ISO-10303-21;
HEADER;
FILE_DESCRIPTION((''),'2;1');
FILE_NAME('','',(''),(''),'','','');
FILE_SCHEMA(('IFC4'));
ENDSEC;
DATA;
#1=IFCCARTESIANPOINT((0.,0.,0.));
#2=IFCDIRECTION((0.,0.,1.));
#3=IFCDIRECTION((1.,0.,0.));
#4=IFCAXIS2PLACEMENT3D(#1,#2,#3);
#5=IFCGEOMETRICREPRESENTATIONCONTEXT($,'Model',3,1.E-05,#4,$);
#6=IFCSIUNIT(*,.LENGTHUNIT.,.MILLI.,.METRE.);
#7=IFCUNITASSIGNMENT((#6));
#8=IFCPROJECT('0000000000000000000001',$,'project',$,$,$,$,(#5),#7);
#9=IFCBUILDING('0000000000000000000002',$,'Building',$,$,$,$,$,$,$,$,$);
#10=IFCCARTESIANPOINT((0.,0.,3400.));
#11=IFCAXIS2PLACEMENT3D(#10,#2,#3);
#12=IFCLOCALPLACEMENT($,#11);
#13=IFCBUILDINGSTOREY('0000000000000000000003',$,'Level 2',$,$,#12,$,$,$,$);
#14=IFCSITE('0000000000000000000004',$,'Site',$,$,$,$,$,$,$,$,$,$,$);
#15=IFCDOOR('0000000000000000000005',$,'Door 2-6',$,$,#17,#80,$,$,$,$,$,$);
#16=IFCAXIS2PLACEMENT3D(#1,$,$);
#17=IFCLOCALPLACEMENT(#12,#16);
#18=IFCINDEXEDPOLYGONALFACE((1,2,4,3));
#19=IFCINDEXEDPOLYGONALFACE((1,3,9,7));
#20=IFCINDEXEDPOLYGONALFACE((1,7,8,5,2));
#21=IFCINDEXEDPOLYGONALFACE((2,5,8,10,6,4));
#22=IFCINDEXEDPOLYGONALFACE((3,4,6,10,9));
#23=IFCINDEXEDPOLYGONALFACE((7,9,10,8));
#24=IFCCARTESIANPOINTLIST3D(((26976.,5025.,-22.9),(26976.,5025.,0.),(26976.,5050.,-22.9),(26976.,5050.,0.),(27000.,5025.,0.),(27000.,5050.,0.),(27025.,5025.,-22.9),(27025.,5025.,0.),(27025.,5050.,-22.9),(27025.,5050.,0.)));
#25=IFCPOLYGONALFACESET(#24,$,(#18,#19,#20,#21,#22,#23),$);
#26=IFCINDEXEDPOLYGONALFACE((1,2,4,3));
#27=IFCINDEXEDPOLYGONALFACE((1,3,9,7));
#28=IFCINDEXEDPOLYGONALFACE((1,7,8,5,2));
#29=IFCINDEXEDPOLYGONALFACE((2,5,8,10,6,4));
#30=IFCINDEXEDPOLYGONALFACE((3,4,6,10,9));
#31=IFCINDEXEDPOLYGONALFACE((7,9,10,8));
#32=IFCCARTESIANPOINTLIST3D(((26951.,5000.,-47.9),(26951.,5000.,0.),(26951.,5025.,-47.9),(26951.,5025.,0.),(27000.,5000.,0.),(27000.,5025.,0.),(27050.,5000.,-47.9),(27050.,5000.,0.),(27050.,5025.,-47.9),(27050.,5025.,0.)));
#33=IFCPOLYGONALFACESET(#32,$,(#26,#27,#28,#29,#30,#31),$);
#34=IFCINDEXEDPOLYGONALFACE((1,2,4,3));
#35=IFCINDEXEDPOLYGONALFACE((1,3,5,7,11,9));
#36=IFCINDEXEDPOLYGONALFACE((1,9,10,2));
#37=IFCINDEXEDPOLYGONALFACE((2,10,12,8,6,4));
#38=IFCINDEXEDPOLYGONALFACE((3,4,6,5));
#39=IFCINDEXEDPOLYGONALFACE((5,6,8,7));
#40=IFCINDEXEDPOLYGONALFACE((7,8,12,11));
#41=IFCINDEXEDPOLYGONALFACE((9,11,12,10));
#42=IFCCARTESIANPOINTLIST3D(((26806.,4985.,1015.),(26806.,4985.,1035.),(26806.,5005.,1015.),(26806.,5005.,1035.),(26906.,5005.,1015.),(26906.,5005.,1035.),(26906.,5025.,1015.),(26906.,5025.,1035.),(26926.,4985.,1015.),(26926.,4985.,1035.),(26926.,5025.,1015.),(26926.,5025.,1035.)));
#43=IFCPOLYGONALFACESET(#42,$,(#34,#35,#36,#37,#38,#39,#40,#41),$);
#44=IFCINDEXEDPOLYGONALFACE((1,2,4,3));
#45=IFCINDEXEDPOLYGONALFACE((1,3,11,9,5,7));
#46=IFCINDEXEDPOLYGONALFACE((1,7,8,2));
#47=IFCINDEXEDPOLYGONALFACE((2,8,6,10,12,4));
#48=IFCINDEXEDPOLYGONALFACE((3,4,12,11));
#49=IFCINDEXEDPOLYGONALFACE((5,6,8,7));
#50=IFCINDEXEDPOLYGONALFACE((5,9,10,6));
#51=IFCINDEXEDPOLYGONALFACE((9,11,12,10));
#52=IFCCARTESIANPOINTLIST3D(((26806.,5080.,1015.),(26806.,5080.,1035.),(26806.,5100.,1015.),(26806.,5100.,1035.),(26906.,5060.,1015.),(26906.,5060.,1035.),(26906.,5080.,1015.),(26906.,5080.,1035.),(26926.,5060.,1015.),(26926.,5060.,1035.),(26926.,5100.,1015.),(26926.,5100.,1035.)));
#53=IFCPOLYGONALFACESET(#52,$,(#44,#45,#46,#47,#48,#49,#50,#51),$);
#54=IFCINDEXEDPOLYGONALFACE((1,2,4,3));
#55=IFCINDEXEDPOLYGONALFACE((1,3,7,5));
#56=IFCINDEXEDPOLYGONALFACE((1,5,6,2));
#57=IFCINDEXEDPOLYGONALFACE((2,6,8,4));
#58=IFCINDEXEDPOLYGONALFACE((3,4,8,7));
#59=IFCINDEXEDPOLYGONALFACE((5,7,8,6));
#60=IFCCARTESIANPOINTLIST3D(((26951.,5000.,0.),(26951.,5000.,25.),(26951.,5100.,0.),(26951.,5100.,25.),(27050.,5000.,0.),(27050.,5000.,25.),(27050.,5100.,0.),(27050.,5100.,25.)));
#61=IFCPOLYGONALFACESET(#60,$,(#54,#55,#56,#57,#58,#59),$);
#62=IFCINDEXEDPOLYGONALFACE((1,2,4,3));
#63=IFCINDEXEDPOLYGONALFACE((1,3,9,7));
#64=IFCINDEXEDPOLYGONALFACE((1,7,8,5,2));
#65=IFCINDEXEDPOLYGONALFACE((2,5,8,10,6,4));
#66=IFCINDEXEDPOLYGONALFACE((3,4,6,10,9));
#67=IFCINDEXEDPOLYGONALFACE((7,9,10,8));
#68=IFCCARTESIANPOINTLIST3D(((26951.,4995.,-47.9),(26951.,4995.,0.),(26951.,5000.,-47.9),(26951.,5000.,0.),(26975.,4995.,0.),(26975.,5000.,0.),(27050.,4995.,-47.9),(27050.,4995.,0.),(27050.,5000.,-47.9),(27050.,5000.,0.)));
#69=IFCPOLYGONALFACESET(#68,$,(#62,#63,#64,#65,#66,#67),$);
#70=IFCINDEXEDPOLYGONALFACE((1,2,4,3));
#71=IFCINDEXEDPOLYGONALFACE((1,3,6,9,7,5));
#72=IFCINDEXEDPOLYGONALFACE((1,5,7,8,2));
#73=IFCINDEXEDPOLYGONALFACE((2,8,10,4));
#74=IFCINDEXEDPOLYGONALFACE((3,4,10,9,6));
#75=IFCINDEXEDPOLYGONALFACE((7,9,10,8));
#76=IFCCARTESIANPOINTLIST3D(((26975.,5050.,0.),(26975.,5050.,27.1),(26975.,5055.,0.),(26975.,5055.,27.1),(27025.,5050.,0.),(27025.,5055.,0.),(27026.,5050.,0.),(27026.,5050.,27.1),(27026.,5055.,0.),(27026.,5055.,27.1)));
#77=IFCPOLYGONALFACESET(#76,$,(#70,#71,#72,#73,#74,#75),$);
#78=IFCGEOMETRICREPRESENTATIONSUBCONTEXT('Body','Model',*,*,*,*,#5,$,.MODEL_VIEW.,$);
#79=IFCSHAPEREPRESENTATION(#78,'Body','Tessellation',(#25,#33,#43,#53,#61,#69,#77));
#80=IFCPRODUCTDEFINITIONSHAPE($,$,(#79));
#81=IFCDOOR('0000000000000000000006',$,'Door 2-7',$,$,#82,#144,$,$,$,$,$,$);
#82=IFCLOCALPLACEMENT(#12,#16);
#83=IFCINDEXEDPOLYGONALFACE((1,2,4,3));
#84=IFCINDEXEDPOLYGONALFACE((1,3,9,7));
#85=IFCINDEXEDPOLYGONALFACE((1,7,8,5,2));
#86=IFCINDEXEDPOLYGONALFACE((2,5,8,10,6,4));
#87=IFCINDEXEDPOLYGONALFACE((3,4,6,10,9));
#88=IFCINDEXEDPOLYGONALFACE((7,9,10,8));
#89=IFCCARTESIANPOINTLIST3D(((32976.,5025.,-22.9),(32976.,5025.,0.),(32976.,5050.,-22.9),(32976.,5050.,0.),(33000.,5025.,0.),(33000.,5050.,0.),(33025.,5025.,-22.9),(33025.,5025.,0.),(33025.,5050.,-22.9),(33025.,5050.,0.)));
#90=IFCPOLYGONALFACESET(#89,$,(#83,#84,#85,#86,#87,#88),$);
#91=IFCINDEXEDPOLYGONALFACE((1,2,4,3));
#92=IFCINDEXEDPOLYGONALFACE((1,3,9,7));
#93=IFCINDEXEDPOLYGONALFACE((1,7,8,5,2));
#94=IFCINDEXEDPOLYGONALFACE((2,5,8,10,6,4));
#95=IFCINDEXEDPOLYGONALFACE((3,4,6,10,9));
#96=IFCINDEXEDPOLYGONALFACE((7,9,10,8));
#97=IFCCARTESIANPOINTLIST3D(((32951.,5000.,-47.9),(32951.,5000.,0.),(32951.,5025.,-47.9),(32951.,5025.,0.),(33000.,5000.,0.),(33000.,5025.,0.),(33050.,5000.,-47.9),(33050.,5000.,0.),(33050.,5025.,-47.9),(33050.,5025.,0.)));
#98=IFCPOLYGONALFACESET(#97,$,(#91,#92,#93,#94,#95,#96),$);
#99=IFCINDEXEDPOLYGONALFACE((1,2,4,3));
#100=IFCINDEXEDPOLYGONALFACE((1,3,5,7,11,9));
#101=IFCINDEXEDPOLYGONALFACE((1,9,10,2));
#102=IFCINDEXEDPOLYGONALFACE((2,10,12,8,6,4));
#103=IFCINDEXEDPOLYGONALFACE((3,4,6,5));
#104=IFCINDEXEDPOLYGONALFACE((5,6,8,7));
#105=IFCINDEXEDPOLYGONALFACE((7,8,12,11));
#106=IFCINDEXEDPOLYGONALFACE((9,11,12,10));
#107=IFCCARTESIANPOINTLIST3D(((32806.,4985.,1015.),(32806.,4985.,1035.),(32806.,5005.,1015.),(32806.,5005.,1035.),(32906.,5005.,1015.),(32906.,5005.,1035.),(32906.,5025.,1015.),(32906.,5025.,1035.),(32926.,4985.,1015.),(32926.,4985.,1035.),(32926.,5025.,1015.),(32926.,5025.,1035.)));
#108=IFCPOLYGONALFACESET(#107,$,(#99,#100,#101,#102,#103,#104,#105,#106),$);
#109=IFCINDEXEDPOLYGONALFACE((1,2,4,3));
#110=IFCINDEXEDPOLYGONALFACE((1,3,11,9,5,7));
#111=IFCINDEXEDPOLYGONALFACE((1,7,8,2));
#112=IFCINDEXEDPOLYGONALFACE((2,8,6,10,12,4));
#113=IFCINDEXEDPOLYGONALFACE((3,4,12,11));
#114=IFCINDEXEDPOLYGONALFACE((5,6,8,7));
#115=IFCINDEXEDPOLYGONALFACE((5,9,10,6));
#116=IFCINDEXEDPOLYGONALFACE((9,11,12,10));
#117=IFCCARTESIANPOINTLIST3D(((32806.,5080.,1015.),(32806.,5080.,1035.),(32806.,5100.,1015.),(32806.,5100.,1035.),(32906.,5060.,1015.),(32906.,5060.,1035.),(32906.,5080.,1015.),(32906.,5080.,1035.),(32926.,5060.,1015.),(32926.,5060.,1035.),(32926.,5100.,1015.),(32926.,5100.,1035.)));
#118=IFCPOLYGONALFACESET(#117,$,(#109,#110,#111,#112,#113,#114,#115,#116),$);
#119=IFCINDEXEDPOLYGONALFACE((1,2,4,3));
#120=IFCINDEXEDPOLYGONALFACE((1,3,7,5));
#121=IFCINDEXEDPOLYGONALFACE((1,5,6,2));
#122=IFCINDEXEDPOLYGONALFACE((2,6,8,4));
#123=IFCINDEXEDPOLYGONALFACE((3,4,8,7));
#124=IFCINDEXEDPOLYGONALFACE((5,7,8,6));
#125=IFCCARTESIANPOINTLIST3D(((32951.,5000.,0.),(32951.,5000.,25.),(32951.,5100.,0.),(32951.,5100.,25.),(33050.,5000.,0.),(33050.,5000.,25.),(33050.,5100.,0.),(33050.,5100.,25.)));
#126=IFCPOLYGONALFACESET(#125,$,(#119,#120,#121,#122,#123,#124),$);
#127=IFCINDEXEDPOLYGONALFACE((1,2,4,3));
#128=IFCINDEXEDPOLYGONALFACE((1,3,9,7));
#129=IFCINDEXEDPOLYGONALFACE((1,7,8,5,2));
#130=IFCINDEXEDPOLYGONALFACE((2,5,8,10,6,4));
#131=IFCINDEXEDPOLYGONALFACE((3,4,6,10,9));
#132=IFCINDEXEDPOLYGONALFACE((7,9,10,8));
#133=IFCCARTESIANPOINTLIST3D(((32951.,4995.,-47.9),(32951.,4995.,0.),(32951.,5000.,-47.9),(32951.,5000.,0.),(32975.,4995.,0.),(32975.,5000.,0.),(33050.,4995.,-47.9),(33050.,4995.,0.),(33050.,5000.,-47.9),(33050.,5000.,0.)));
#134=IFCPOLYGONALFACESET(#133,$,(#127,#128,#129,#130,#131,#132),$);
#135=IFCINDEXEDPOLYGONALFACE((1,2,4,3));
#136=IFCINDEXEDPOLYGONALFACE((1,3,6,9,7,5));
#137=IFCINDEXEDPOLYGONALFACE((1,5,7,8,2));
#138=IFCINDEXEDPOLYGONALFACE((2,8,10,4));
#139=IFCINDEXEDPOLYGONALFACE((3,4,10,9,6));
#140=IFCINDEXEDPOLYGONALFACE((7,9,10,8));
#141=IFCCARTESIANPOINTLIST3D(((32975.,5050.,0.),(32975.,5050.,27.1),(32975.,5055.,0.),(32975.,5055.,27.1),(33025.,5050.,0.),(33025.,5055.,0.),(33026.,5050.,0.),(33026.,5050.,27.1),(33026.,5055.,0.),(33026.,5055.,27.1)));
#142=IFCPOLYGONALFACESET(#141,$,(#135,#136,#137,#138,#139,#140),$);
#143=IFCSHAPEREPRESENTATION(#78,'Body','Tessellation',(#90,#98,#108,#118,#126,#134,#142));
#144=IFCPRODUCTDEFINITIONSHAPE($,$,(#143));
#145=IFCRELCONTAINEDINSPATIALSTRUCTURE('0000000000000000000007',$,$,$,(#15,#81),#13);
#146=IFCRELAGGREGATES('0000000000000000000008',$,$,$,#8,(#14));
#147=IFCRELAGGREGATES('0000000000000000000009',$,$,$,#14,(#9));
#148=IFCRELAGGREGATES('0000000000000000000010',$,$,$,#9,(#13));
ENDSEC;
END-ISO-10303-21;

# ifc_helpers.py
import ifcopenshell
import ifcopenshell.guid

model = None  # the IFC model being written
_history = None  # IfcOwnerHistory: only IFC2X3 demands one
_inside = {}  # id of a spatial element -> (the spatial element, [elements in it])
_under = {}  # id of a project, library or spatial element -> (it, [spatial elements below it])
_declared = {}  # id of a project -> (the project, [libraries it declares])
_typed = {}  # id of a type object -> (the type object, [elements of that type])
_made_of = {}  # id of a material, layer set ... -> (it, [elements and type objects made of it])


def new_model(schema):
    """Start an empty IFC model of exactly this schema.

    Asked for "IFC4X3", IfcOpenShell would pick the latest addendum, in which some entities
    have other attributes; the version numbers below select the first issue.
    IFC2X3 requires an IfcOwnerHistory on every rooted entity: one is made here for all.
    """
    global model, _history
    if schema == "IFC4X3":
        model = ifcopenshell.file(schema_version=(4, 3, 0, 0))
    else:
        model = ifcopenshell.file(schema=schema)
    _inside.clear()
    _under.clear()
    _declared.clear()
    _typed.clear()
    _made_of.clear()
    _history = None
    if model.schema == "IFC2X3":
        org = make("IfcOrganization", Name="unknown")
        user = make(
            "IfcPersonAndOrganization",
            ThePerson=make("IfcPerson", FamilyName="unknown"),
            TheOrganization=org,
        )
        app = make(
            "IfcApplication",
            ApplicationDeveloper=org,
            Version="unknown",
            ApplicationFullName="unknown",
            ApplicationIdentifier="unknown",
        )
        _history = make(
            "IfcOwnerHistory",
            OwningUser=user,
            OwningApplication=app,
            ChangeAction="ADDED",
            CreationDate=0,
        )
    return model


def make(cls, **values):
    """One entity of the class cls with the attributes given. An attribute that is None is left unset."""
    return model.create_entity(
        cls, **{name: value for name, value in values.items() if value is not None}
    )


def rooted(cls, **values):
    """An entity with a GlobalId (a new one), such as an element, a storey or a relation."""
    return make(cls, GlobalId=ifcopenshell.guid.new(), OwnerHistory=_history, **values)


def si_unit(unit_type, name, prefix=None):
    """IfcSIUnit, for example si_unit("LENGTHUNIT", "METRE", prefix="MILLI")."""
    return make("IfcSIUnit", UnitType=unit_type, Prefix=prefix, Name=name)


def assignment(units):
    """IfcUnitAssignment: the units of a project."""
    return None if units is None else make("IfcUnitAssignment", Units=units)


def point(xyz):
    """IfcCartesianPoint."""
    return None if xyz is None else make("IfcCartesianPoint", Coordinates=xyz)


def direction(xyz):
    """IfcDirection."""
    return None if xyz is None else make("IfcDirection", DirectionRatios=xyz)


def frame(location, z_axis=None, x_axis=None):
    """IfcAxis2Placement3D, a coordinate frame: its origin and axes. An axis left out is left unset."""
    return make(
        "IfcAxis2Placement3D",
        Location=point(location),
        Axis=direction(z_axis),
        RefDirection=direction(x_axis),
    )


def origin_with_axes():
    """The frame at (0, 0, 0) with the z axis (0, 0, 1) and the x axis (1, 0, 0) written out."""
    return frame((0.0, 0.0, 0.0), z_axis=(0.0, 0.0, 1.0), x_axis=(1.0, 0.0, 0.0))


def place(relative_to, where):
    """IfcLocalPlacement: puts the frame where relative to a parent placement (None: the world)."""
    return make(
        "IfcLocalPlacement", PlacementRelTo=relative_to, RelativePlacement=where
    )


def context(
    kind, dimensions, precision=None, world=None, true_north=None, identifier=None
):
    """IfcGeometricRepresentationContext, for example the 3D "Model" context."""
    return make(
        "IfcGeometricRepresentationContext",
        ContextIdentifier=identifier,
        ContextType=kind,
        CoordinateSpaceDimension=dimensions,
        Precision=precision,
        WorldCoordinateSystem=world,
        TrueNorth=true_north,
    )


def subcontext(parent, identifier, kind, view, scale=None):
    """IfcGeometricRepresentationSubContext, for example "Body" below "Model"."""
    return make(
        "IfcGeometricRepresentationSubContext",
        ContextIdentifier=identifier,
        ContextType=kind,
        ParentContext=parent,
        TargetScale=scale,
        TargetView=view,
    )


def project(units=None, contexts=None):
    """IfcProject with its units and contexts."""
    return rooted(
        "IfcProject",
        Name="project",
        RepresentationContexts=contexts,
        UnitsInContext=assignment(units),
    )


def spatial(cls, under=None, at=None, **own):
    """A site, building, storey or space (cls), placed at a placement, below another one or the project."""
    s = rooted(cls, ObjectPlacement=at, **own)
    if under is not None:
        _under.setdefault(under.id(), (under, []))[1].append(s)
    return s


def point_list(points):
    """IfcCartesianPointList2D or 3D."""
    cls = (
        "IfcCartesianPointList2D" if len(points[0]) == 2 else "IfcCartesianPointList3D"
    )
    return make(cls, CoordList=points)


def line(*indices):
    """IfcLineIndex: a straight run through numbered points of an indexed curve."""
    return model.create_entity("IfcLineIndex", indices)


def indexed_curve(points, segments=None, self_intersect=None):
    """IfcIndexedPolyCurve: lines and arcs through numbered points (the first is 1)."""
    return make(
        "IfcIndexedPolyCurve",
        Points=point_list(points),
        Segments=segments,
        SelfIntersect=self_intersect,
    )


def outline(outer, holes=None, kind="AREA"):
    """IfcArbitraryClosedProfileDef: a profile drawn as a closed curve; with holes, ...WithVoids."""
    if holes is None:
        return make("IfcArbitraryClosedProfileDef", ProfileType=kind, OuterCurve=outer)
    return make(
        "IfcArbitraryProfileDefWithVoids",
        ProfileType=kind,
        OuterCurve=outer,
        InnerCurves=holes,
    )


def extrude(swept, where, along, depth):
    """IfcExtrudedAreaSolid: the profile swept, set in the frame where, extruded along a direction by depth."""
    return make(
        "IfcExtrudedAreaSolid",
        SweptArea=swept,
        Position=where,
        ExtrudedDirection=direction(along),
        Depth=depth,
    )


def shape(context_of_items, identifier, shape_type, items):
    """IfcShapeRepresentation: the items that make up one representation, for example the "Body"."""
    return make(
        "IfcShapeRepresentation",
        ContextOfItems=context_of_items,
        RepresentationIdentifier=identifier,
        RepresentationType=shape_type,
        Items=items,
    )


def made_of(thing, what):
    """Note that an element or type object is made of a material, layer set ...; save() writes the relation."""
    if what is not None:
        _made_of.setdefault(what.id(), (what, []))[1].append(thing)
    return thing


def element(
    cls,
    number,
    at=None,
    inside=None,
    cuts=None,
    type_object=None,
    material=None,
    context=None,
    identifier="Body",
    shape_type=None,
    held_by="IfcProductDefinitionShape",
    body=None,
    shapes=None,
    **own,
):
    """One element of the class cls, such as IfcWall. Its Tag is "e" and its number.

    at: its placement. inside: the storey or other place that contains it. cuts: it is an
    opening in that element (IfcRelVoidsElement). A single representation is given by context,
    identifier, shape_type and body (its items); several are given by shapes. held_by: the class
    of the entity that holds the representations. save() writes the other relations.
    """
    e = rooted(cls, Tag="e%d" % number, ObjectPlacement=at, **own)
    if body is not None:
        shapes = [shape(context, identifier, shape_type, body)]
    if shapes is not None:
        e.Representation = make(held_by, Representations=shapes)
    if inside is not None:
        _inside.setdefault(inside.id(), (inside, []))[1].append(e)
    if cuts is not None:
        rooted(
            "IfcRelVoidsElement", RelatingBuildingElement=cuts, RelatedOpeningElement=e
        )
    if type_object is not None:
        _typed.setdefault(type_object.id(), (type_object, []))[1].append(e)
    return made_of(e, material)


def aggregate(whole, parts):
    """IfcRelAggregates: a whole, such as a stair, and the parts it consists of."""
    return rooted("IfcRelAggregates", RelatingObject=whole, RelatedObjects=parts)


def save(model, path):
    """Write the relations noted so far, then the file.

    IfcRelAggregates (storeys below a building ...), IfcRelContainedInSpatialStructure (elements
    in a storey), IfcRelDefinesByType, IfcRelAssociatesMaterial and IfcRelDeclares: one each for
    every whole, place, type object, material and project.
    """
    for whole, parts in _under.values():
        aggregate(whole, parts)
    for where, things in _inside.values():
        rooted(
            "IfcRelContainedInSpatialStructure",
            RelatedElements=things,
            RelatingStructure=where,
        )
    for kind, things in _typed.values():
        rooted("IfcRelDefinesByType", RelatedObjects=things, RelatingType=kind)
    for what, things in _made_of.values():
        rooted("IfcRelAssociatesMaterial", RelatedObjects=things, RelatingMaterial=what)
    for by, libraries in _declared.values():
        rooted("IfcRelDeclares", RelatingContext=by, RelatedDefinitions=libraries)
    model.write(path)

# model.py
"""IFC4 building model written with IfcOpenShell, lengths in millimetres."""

from ifc_helpers import new_model, si_unit, frame, origin_with_axes, place, context, subcontext, project, spatial, line, indexed_curve, outline, extrude, element, save


model = new_model("IFC4")

# Units and contexts
model_context = context("Model", 3, precision=1e-05, world=origin_with_axes())
body_context = subcontext(model_context, "Body", "Model", "MODEL_VIEW")
ifc_project = project(units=[si_unit("LENGTHUNIT", "METRE", prefix="MILLI")], contexts=[model_context])

# Site, building, storey
site = spatial("IfcSite", under=ifc_project, Name="Site")
building = spatial("IfcBuilding", under=site, Name="Building")
storey_placement = place(None, frame((0.0, 0.0, 3400.0), z_axis=(0.0, 0.0, 1.0), x_axis=(1.0, 0.0, 0.0)))
storey = spatial("IfcBuildingStorey", under=building, at=storey_placement, Name="Level 2")

# Doors
door_1_placement = place(storey_placement, frame((27000.0, 5000.0, 0.0), z_axis=(0.0, 0.0, 1.0), x_axis=(1.0, 0.0, 0.0)))
element("IfcDoor", 1, at=door_1_placement, inside=storey, Name="Door 2-6", context=body_context, shape_type="SweptSolid", body=[
    extrude(outline(indexed_curve([(0.0, 0.0), (0.0, 2.1), (1.0, 2.1), (1.0, 0.0), (-24.0, 0.0), (-24.0, -22.9), (25.0, -22.9), (25.0, 0.0)], segments=[line(1, 2, 3, 4, 5, 6, 7, 8, 1)])), frame((0.0, 25.0, 0.0), z_axis=(0.0, -1.0, 0.0), x_axis=(1.0, 0.0, 0.0)), (0.0, 0.0, -1.0), 25.0),
    extrude(outline(indexed_curve([(0.0, 0.0), (0.0, 2.1), (1.0, 2.1), (1.0, 0.0), (-49.0, 0.0), (-49.0, -47.9), (50.0, -47.9), (50.0, 0.0)], segments=[line(1, 2, 3, 4, 5, 6, 7, 8, 1)])), frame((0.0, 0.0, 0.0), z_axis=(0.0, -1.0, 0.0), x_axis=(1.0, 0.0, 0.0)), (0.0, 0.0, -1.0), 25.0),
    extrude(outline(indexed_curve([(0.0, 0.0), (-49.0, 0.0), (-49.0, 35.0), (0.0, 35.0)], segments=[line(1, 2, 3, 4, 1)])), frame((25.0, 25.0, 25.0), z_axis=(0.0, 0.0, 1.0), x_axis=(1.0, 0.0, 0.0)), (0.0, 0.0, 1.0), -47.9),
    extrude(outline(indexed_curve([(0.0, 0.0), (0.0, -40.0), (-120.0, -40.0), (-120.0, -20.0), (-20.0, -20.0), (-20.0, 0.0)], segments=[line(1, 2, 3, 4, 5, 6, 1)])), frame((-74.0, 25.0, 1015.0), z_axis=(0.0, 0.0, 1.0), x_axis=(1.0, 0.0, 0.0)), (0.0, 0.0, 1.0), 20.0),
    extrude(outline(indexed_curve([(0.0, 0.0), (0.0, 40.0), (-120.0, 40.0), (-120.0, 20.0), (-20.0, 20.0), (-20.0, 0.0)], segments=[line(1, 2, 3, 4, 5, 6, 1)])), frame((-74.0, 60.0, 1015.0), z_axis=(0.0, 0.0, 1.0), x_axis=(1.0, 0.0, 0.0)), (0.0, 0.0, 1.0), 20.0),
    extrude(outline(indexed_curve([(0.0, 0.0), (-99.0, 0.0), (-99.0, 100.0), (0.0, 100.0)], segments=[line(1, 2, 3, 4, 1)])), frame((50.0, 0.0, 0.0), z_axis=(0.0, 0.0, 1.0), x_axis=(1.0, 0.0, 0.0)), (0.0, 0.0, 1.0), 25.0),
    extrude(outline(indexed_curve([(0.0, 0.0), (0.0, 27.1), (51.0, 27.1), (51.0, 0.0), (-24.0, 0.0), (-24.0, -47.9), (75.0, -47.9), (75.0, 0.0)], segments=[line(1, 2, 3, 4, 5, 6, 7, 8, 1)])), frame((-25.0, -5.0, 0.0), z_axis=(0.0, -1.0, 0.0), x_axis=(1.0, 0.0, 0.0)), (0.0, 0.0, -1.0), 5.0),
    extrude(outline(indexed_curve([(0.0, 0.0), (0.0, 27.1), (51.0, 27.1), (51.0, 0.0), (1.0, 0.0), (1.0, -22.9), (50.0, -22.9), (50.0, 0.0)], segments=[line(1, 2, 3, 4, 5, 6, 7, 8, 1)])), frame((-25.0, 50.0, 0.0), z_axis=(0.0, -1.0, 0.0), x_axis=(1.0, 0.0, 0.0)), (0.0, 0.0, -1.0), 5.0),
])
door_2_placement = place(storey_placement, frame((33000.0, 5000.0, 0.0), z_axis=(0.0, 0.0, 1.0), x_axis=(1.0, 0.0, 0.0)))
element("IfcDoor", 2, at=door_2_placement, inside=storey, Name="Door 2-7", context=body_context, shape_type="SweptSolid", body=[
    extrude(outline(indexed_curve([(0.0, 0.0), (0.0, 2.1), (1.0, 2.1), (1.0, 0.0), (-24.0, 0.0), (-24.0, -22.9), (25.0, -22.9), (25.0, 0.0)], segments=[line(1, 2, 3, 4, 5, 6, 7, 8, 1)])), frame((0.0, 25.0, 0.0), z_axis=(0.0, -1.0, 0.0), x_axis=(1.0, 0.0, 0.0)), (0.0, 0.0, -1.0), 25.0),
    extrude(outline(indexed_curve([(0.0, 0.0), (0.0, 2.1), (1.0, 2.1), (1.0, 0.0), (-49.0, 0.0), (-49.0, -47.9), (50.0, -47.9), (50.0, 0.0)], segments=[line(1, 2, 3, 4, 5, 6, 7, 8, 1)])), frame((0.0, 0.0, 0.0), z_axis=(0.0, -1.0, 0.0), x_axis=(1.0, 0.0, 0.0)), (0.0, 0.0, -1.0), 25.0),
    extrude(outline(indexed_curve([(0.0, 0.0), (-49.0, 0.0), (-49.0, 35.0), (0.0, 35.0)], segments=[line(1, 2, 3, 4, 1)])), frame((25.0, 25.0, 25.0), z_axis=(0.0, 0.0, 1.0), x_axis=(1.0, 0.0, 0.0)), (0.0, 0.0, 1.0), -47.9),
    extrude(outline(indexed_curve([(0.0, 0.0), (0.0, -40.0), (-120.0, -40.0), (-120.0, -20.0), (-20.0, -20.0), (-20.0, 0.0)], segments=[line(1, 2, 3, 4, 5, 6, 1)])), frame((-74.0, 25.0, 1015.0), z_axis=(0.0, 0.0, 1.0), x_axis=(1.0, 0.0, 0.0)), (0.0, 0.0, 1.0), 20.0),
    extrude(outline(indexed_curve([(0.0, 0.0), (0.0, 40.0), (-120.0, 40.0), (-120.0, 20.0), (-20.0, 20.0), (-20.0, 0.0)], segments=[line(1, 2, 3, 4, 5, 6, 1)])), frame((-74.0, 60.0, 1015.0), z_axis=(0.0, 0.0, 1.0), x_axis=(1.0, 0.0, 0.0)), (0.0, 0.0, 1.0), 20.0),
    extrude(outline(indexed_curve([(0.0, 0.0), (-99.0, 0.0), (-99.0, 100.0), (0.0, 100.0)], segments=[line(1, 2, 3, 4, 1)])), frame((50.0, 0.0, 0.0), z_axis=(0.0, 0.0, 1.0), x_axis=(1.0, 0.0, 0.0)), (0.0, 0.0, 1.0), 25.0),
    extrude(outline(indexed_curve([(0.0, 0.0), (0.0, 27.1), (51.0, 27.1), (51.0, 0.0), (-24.0, 0.0), (-24.0, -47.9), (75.0, -47.9), (75.0, 0.0)], segments=[line(1, 2, 3, 4, 5, 6, 7, 8, 1)])), frame((-25.0, -5.0, 0.0), z_axis=(0.0, -1.0, 0.0), x_axis=(1.0, 0.0, 0.0)), (0.0, 0.0, -1.0), 5.0),
    extrude(outline(indexed_curve([(0.0, 0.0), (0.0, 27.1), (51.0, 27.1), (51.0, 0.0), (1.0, 0.0), (1.0, -22.9), (50.0, -22.9), (50.0, 0.0)], segments=[line(1, 2, 3, 4, 5, 6, 7, 8, 1)])), frame((-25.0, 50.0, 0.0), z_axis=(0.0, -1.0, 0.0), x_axis=(1.0, 0.0, 0.0)), (0.0, 0.0, -1.0), 5.0),
])

save(model, "model.ifc")
